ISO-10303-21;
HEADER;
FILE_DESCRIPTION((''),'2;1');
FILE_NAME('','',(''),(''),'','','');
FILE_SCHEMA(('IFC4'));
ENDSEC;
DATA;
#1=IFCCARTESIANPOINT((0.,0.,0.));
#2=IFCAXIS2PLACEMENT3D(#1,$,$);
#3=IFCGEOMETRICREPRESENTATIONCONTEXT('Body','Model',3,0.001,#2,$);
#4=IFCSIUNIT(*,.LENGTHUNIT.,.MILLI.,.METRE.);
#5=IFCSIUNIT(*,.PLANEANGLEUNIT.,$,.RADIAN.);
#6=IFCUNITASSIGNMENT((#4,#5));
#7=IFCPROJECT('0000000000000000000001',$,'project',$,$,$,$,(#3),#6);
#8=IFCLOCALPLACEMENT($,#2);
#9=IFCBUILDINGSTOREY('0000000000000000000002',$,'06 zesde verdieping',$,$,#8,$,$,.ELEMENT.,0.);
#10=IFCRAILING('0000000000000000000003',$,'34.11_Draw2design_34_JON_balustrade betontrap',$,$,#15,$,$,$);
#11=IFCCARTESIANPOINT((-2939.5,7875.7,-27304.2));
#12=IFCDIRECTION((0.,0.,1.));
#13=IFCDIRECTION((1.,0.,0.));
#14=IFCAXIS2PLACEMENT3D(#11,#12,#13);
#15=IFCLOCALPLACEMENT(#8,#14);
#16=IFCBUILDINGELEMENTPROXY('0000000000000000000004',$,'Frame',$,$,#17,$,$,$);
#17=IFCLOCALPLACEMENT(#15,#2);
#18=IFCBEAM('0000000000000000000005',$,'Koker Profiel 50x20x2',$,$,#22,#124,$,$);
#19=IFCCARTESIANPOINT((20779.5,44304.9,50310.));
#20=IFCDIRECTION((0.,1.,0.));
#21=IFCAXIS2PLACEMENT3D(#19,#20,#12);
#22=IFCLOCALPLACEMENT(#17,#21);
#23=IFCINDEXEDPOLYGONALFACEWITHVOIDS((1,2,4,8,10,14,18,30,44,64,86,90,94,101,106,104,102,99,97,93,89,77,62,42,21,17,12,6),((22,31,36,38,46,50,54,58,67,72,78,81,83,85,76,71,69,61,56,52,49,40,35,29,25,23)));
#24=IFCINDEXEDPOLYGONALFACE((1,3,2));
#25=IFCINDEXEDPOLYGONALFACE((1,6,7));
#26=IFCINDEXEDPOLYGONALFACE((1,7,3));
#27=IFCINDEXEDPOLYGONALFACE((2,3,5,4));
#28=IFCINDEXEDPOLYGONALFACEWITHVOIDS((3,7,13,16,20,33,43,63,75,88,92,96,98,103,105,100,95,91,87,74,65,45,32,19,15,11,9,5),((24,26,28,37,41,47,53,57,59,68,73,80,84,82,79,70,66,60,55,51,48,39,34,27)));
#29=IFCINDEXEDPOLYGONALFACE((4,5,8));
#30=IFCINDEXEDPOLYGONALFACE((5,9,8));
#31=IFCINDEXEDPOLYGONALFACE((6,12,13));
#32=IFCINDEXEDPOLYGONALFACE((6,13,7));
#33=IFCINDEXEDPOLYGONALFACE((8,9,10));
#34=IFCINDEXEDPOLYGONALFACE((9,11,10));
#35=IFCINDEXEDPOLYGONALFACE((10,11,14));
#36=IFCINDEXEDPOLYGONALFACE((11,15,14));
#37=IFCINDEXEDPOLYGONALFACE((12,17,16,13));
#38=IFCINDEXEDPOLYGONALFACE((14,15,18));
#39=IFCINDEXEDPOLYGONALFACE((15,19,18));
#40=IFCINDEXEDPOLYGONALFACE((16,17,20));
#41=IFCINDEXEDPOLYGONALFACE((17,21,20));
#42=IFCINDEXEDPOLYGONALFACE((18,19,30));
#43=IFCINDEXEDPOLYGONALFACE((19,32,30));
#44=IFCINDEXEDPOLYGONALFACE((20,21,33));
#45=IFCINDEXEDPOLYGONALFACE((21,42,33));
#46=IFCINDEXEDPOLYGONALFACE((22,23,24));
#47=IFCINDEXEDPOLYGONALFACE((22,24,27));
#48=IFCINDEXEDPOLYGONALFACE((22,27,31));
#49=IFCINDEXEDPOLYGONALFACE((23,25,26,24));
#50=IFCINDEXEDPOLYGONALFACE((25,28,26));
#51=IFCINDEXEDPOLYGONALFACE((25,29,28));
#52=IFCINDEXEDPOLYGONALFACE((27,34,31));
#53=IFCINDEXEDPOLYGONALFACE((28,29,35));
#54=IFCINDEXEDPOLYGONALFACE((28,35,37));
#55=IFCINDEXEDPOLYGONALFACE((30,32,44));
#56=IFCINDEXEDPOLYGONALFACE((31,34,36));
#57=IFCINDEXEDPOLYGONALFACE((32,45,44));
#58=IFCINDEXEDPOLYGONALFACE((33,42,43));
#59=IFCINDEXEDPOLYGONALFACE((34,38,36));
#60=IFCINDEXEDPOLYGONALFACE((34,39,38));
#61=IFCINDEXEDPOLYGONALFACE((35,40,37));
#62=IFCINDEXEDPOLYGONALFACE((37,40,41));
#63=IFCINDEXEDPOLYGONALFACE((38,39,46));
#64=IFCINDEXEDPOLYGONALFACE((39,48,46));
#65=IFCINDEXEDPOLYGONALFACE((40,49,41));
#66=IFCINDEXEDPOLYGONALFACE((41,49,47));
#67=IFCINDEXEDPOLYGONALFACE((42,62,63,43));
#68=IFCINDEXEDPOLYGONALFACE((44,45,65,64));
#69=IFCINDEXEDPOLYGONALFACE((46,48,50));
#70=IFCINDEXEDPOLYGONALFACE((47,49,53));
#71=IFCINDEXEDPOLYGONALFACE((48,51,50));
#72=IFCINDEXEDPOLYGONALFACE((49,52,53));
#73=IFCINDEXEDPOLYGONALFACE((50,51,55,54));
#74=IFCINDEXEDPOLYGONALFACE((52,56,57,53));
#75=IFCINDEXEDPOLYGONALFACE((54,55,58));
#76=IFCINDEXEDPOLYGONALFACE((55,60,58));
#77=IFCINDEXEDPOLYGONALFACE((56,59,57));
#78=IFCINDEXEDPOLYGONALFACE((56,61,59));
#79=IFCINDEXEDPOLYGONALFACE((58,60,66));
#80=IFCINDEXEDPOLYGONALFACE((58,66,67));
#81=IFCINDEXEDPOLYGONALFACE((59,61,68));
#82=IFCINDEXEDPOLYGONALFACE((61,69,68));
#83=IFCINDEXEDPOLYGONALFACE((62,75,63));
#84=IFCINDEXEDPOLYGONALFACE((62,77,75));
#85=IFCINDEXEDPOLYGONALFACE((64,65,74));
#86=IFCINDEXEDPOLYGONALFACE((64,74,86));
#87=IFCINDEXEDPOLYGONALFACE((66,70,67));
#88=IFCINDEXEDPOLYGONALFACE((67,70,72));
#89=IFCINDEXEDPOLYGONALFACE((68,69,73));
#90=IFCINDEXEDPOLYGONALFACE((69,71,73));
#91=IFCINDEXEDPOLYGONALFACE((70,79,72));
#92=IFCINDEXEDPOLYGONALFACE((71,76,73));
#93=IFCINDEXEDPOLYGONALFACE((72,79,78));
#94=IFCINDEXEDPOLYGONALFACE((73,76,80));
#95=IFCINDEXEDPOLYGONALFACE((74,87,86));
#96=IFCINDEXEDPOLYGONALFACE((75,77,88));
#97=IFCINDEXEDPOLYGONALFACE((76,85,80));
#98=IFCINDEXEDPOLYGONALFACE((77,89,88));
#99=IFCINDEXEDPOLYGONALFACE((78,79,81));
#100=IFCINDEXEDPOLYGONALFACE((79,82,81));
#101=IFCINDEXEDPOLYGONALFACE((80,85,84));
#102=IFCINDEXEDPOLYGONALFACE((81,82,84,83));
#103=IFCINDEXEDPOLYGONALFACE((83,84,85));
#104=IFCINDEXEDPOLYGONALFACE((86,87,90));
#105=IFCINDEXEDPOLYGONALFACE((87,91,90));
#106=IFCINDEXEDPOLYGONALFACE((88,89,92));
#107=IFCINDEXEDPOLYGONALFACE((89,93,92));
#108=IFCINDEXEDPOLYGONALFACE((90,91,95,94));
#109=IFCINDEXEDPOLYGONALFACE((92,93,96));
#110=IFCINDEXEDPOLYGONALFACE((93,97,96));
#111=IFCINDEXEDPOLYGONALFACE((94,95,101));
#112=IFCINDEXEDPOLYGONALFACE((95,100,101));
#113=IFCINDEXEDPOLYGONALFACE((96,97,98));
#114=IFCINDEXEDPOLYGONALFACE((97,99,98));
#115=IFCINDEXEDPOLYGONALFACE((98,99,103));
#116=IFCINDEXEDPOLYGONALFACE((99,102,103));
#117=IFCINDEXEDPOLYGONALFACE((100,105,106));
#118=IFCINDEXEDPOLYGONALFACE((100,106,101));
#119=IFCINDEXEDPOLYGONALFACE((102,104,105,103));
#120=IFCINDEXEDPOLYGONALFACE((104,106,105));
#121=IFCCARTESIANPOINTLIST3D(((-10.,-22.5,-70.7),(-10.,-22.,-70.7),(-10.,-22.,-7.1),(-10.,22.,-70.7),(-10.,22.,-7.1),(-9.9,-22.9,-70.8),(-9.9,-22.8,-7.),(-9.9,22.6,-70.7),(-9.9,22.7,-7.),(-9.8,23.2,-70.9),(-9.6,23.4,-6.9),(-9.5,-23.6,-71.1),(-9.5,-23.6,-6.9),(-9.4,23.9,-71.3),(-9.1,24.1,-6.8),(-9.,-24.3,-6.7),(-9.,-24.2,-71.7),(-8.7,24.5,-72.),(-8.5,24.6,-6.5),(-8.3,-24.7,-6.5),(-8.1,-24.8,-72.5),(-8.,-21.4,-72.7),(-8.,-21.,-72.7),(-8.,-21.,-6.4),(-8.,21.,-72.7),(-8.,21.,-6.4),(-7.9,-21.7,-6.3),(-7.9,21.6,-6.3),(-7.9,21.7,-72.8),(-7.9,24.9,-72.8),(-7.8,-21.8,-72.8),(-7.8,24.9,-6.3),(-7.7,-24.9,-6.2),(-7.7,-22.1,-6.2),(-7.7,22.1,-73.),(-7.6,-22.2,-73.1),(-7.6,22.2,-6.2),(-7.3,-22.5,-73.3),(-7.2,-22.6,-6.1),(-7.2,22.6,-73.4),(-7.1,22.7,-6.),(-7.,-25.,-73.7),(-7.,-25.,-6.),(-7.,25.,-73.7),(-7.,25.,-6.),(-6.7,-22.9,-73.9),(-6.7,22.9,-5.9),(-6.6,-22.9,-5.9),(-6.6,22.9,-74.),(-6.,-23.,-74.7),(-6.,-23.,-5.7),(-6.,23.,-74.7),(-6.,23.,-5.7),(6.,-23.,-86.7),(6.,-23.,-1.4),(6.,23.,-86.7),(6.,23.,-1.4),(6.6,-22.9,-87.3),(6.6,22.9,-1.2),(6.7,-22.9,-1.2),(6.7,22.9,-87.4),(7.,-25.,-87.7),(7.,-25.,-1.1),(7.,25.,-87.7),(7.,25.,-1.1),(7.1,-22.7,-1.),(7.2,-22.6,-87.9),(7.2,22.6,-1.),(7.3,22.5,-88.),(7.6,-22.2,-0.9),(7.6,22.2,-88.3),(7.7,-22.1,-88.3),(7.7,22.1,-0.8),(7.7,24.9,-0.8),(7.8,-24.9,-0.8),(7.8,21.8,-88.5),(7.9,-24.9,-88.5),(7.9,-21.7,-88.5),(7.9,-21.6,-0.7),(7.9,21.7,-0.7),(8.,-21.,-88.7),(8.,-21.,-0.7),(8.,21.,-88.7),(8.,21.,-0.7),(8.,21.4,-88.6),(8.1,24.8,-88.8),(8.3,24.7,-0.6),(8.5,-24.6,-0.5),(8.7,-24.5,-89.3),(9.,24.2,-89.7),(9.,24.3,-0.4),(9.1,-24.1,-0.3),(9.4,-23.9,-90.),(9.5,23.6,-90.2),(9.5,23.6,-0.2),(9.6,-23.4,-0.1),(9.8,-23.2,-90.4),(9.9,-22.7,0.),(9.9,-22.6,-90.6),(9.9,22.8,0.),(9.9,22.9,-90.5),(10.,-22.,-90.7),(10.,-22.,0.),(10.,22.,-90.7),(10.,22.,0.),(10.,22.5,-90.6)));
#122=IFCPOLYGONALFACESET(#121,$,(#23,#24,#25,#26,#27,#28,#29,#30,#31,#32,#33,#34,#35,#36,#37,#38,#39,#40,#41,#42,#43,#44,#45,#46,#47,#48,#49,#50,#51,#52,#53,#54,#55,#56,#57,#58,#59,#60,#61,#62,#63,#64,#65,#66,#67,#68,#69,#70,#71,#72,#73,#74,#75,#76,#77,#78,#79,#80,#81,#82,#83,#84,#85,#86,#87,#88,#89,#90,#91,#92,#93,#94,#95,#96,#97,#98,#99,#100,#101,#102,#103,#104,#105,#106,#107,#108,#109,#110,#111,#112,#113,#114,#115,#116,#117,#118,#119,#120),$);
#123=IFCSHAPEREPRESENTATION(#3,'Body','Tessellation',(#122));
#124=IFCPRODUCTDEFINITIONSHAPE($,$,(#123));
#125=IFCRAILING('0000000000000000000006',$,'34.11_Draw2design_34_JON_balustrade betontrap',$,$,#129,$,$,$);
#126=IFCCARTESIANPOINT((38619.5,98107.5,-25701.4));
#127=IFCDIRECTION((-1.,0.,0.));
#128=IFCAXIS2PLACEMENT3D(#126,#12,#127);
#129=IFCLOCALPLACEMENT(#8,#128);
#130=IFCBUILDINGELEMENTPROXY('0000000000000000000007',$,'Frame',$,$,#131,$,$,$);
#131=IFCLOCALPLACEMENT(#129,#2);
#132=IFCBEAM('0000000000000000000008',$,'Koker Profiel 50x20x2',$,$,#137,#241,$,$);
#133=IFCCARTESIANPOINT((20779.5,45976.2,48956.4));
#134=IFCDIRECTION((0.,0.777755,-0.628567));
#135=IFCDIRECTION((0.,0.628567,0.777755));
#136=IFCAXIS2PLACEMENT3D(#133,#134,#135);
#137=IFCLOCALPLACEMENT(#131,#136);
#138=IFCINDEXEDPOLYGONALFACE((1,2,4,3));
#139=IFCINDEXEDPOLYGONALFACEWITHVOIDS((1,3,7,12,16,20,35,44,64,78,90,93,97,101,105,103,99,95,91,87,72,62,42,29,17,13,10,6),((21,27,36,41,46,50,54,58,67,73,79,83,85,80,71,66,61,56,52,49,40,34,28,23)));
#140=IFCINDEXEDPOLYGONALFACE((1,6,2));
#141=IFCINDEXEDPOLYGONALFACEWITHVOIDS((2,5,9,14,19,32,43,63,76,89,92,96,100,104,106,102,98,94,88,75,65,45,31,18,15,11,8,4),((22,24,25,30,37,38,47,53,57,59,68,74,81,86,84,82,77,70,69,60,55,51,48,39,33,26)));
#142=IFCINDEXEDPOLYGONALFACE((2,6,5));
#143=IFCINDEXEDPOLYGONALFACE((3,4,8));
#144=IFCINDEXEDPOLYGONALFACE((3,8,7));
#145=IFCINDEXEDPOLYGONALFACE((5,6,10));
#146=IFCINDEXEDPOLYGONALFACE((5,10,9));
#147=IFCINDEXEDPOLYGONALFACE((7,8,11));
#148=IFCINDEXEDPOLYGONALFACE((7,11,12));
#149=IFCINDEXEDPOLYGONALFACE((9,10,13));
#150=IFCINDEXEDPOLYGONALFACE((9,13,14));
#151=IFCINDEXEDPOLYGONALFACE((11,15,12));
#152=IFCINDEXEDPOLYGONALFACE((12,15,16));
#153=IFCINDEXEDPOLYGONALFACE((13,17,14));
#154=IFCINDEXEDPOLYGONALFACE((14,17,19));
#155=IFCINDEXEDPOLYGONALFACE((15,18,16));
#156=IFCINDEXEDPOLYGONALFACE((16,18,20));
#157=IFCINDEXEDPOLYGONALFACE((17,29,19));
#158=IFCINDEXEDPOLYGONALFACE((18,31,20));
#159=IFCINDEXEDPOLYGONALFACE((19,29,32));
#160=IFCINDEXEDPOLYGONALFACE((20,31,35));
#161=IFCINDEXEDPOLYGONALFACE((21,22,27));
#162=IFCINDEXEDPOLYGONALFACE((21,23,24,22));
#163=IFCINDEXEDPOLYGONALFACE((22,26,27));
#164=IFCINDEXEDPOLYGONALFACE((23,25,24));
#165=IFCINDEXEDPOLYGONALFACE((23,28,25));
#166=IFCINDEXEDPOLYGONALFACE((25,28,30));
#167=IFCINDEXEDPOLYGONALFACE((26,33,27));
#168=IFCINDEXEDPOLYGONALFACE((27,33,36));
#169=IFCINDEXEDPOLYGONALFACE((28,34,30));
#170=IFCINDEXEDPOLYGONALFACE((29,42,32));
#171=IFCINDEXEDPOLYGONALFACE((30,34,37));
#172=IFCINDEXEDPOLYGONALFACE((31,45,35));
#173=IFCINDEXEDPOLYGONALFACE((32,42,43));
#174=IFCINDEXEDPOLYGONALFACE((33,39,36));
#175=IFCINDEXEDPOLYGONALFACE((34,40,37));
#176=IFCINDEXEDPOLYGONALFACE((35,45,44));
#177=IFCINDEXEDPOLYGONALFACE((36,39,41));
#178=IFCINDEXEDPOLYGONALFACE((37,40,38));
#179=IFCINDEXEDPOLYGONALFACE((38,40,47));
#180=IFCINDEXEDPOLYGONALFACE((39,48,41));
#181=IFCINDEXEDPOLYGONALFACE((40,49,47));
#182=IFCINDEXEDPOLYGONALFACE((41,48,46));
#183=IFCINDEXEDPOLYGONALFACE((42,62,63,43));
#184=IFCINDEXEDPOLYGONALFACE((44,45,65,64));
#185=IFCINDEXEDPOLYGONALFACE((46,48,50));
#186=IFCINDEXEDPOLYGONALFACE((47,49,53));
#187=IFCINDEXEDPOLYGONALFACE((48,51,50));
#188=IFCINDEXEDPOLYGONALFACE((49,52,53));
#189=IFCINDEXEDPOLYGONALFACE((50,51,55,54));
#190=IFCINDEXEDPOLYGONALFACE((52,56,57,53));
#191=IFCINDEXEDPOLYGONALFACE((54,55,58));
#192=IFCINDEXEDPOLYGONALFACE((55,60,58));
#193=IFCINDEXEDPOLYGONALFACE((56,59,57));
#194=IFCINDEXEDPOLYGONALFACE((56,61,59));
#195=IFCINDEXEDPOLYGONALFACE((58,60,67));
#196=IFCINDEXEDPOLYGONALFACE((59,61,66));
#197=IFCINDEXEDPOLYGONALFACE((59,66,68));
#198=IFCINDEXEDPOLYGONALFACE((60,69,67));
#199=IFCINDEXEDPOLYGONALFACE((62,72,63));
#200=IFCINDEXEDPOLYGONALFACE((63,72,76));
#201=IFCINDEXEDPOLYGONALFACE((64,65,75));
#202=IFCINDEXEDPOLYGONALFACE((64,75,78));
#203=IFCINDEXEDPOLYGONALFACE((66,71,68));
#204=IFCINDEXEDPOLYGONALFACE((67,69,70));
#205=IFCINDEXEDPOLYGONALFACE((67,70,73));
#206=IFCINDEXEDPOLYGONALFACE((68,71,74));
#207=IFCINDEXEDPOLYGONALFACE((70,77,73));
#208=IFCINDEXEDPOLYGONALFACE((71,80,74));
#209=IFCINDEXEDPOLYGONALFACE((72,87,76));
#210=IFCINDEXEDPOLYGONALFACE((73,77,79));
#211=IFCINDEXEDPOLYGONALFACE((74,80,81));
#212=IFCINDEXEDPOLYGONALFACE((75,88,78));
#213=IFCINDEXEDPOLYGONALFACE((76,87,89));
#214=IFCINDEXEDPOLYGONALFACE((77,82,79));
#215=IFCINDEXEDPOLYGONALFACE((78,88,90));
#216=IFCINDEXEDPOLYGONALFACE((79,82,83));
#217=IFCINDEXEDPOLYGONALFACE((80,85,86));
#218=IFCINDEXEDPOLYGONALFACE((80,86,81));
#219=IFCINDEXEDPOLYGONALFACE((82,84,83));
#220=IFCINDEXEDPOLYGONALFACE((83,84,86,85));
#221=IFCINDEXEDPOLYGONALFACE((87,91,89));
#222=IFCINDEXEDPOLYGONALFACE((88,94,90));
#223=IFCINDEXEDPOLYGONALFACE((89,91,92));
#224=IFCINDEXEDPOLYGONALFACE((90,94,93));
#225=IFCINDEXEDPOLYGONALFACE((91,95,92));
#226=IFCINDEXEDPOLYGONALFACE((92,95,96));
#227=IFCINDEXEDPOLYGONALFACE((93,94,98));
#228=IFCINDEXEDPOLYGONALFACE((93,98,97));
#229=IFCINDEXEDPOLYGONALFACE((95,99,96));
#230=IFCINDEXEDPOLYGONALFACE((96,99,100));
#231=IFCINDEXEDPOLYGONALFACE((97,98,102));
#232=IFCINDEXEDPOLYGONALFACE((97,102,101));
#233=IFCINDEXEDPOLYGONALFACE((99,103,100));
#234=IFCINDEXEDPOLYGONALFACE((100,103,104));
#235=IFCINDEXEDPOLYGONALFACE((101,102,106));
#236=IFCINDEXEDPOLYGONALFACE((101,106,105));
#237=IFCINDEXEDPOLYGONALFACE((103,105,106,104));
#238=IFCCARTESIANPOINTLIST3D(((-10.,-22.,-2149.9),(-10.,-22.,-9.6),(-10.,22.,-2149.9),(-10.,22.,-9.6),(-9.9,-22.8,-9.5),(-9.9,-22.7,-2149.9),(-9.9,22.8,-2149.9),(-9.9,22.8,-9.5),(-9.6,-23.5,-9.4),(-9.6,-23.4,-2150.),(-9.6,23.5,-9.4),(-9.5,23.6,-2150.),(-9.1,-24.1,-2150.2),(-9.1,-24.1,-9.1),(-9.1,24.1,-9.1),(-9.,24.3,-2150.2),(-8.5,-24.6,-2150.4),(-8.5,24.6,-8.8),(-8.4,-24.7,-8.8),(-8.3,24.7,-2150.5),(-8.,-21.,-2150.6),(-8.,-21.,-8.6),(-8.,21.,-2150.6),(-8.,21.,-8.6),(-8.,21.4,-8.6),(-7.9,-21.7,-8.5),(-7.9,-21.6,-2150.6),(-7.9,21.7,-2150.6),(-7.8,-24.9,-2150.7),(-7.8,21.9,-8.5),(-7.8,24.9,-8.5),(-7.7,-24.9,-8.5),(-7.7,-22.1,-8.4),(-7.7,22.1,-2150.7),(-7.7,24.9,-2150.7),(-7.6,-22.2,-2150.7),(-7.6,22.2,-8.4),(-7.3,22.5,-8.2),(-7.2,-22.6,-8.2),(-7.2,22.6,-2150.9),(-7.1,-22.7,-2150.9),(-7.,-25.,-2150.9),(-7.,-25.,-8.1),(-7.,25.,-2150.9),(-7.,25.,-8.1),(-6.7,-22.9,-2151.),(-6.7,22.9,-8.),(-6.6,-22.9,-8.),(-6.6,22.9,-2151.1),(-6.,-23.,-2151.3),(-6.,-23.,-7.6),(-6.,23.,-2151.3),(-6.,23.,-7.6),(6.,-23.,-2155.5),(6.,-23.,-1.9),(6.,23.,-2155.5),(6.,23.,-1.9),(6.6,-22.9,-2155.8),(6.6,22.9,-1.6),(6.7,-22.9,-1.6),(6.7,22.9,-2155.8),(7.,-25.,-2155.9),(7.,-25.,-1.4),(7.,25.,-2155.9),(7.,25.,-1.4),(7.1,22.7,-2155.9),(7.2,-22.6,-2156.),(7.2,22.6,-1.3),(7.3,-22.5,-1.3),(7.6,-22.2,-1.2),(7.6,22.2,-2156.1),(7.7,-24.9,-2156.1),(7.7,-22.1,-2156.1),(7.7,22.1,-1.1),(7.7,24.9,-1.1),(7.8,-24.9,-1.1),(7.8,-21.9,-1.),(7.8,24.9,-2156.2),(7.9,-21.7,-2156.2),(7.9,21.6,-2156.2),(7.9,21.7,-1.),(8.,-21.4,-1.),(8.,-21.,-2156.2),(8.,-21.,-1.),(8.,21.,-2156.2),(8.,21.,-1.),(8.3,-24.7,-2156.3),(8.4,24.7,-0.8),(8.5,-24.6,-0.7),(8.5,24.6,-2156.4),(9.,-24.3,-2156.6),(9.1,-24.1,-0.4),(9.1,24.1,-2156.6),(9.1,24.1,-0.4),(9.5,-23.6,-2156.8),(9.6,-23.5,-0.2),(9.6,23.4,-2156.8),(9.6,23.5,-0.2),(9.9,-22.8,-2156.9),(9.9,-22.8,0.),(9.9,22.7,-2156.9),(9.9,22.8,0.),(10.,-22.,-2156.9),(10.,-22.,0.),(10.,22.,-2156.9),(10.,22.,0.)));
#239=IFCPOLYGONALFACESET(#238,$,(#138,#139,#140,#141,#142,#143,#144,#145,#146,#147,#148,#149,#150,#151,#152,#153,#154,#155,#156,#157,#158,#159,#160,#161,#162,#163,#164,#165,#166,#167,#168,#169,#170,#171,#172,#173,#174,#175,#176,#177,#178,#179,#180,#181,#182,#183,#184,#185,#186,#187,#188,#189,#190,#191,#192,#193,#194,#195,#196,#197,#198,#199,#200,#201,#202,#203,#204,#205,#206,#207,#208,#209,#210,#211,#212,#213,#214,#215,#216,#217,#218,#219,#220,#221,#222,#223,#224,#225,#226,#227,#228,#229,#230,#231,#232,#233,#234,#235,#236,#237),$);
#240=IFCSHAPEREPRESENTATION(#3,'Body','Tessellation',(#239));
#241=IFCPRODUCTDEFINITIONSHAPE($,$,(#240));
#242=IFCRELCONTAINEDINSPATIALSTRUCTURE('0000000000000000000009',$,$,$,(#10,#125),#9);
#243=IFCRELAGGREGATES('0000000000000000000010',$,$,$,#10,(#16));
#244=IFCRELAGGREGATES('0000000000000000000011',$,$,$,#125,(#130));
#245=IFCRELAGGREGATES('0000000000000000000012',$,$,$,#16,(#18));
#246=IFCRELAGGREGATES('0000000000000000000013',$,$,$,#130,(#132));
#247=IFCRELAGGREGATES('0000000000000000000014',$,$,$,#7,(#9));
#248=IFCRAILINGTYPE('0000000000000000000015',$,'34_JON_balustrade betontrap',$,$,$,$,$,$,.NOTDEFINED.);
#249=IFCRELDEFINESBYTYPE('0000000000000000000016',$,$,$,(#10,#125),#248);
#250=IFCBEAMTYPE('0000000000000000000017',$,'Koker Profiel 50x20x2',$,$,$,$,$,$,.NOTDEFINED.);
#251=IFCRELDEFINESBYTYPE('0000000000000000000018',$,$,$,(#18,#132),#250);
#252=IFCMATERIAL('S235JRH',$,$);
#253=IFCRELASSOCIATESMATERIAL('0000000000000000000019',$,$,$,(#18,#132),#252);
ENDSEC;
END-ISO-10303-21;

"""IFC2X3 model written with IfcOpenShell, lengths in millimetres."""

from ifc_helpers import new_model, si_unit, frame, origin, origin_2d, place, context, project, spatial, hollow_rectangle, extrude, clip, halfspace, source, transform, mapped, material, type_object, element, aggregate, save


model = new_model("IFC2X3")

# Units and contexts
model_context = context("Model", 3, precision=0.001, world=origin(), identifier="Body")
ifc_project = project(units=[si_unit("LENGTHUNIT", "METRE", prefix="MILLI"), si_unit("PLANEANGLEUNIT", "RADIAN")], contexts=[model_context])

# Storey
storey_placement = place(None, origin())
storey = spatial("IfcBuildingStorey", under=ifc_project, at=storey_placement, Name="06 zesde verdieping", CompositionType="ELEMENT", Elevation=0.0)

# Railing, building element proxy, beam
railing_type_1 = type_object("IfcRailingType", Name="34_JON_balustrade betontrap")
railing_1_placement = place(storey_placement, frame((-2939.5, 7875.7, -27304.2), z_axis=(0.0, 0.0, 1.0), x_axis=(1.0, 0.0, 0.0)))
railing_1 = element("IfcRailing", 1, at=railing_1_placement, inside=storey, type_object=railing_type_1, Name="34.11_Draw2design_34_JON_balustrade betontrap")
proxy_1_placement = place(railing_1_placement, origin())
proxy_1 = element("IfcBuildingElementProxy", 2, at=proxy_1_placement, Name="Frame")
aggregate(railing_1, [proxy_1])
ifc_material_1 = material(Name="S235JRH")
beam_type_1 = type_object("IfcBeamType", Name="Koker Profiel 50x20x2")
shared_shape_1 = source(origin(), model_context, "Body", "Clipping", [
    clip(clip(extrude(hollow_rectangle(XDim=20.0, YDim=50.0, WallThickness=2.0, InnerFilletRadius=2.0, OuterFilletRadius=3.0, at=origin_2d()), origin(), (0.0, 0.0, -1.0), 90.7), halfspace(frame((-10.0, 25.0, -7.1), z_axis=(-0.33335, 0.0, 0.942803), x_axis=(0.0, 1.0, 0.0)), False)), halfspace(frame((-10.0, -25.0, -70.7), z_axis=(-0.707107, 0.0, -0.707107), x_axis=(0.0, -1.0, 0.0)), False)),
])
beam_1_placement = place(proxy_1_placement, frame((20779.5, 44304.9, 50310.0), z_axis=(0.0, 1.0, 0.0), x_axis=(0.0, 0.0, 1.0)))
beam_1 = element("IfcBeam", 3, at=beam_1_placement, type_object=beam_type_1, material=ifc_material_1, Name="Koker Profiel 50x20x2", context=model_context, shape_type="MappedRepresentation", body=[
    mapped(shared_shape_1, transform((0.0, 0.0, 0.0), scale=1.0)),
])

# Railing, building element proxy, beam
railing_2_placement = place(storey_placement, frame((38619.5, 98107.5, -25701.4), z_axis=(0.0, 0.0, 1.0), x_axis=(-1.0, 0.0, 0.0)))
railing_2 = element("IfcRailing", 4, at=railing_2_placement, inside=storey, type_object=railing_type_1, Name="34.11_Draw2design_34_JON_balustrade betontrap")
proxy_2_placement = place(railing_2_placement, origin())
proxy_2 = element("IfcBuildingElementProxy", 5, at=proxy_2_placement, Name="Frame")
aggregate(railing_2, [proxy_2])
shared_shape_2 = source(origin(), model_context, "Body", "Clipping", [
    clip(clip(extrude(hollow_rectangle(XDim=20.0, YDim=50.0, WallThickness=2.0, InnerFilletRadius=2.0, OuterFilletRadius=3.0, at=origin_2d()), origin(), (0.0, 0.0, -1.0), 2156.9), halfspace(frame((-10.0, 25.0, -9.6), z_axis=(-0.430948, 0.0, 0.902377), x_axis=(-0.902377, 0.0, -0.430948)), False)), halfspace(frame((-10.0, -25.0, -2149.9), z_axis=(-0.33335, 0.0, -0.942803), x_axis=(0.0, -1.0, 0.0)), False)),
])
beam_2_placement = place(proxy_2_placement, frame((20779.5, 45976.2, 48956.4), z_axis=(0.0, 0.777755, -0.628567), x_axis=(0.0, 0.628567, 0.777755)))
beam_2 = element("IfcBeam", 6, at=beam_2_placement, type_object=beam_type_1, material=ifc_material_1, Name="Koker Profiel 50x20x2", context=model_context, shape_type="MappedRepresentation", body=[
    mapped(shared_shape_2, transform((0.0, 0.0, 0.0), scale=1.0)),
])

aggregate(proxy_1, [beam_1])
aggregate(proxy_2, [beam_2])

save(model, "model.ifc")
